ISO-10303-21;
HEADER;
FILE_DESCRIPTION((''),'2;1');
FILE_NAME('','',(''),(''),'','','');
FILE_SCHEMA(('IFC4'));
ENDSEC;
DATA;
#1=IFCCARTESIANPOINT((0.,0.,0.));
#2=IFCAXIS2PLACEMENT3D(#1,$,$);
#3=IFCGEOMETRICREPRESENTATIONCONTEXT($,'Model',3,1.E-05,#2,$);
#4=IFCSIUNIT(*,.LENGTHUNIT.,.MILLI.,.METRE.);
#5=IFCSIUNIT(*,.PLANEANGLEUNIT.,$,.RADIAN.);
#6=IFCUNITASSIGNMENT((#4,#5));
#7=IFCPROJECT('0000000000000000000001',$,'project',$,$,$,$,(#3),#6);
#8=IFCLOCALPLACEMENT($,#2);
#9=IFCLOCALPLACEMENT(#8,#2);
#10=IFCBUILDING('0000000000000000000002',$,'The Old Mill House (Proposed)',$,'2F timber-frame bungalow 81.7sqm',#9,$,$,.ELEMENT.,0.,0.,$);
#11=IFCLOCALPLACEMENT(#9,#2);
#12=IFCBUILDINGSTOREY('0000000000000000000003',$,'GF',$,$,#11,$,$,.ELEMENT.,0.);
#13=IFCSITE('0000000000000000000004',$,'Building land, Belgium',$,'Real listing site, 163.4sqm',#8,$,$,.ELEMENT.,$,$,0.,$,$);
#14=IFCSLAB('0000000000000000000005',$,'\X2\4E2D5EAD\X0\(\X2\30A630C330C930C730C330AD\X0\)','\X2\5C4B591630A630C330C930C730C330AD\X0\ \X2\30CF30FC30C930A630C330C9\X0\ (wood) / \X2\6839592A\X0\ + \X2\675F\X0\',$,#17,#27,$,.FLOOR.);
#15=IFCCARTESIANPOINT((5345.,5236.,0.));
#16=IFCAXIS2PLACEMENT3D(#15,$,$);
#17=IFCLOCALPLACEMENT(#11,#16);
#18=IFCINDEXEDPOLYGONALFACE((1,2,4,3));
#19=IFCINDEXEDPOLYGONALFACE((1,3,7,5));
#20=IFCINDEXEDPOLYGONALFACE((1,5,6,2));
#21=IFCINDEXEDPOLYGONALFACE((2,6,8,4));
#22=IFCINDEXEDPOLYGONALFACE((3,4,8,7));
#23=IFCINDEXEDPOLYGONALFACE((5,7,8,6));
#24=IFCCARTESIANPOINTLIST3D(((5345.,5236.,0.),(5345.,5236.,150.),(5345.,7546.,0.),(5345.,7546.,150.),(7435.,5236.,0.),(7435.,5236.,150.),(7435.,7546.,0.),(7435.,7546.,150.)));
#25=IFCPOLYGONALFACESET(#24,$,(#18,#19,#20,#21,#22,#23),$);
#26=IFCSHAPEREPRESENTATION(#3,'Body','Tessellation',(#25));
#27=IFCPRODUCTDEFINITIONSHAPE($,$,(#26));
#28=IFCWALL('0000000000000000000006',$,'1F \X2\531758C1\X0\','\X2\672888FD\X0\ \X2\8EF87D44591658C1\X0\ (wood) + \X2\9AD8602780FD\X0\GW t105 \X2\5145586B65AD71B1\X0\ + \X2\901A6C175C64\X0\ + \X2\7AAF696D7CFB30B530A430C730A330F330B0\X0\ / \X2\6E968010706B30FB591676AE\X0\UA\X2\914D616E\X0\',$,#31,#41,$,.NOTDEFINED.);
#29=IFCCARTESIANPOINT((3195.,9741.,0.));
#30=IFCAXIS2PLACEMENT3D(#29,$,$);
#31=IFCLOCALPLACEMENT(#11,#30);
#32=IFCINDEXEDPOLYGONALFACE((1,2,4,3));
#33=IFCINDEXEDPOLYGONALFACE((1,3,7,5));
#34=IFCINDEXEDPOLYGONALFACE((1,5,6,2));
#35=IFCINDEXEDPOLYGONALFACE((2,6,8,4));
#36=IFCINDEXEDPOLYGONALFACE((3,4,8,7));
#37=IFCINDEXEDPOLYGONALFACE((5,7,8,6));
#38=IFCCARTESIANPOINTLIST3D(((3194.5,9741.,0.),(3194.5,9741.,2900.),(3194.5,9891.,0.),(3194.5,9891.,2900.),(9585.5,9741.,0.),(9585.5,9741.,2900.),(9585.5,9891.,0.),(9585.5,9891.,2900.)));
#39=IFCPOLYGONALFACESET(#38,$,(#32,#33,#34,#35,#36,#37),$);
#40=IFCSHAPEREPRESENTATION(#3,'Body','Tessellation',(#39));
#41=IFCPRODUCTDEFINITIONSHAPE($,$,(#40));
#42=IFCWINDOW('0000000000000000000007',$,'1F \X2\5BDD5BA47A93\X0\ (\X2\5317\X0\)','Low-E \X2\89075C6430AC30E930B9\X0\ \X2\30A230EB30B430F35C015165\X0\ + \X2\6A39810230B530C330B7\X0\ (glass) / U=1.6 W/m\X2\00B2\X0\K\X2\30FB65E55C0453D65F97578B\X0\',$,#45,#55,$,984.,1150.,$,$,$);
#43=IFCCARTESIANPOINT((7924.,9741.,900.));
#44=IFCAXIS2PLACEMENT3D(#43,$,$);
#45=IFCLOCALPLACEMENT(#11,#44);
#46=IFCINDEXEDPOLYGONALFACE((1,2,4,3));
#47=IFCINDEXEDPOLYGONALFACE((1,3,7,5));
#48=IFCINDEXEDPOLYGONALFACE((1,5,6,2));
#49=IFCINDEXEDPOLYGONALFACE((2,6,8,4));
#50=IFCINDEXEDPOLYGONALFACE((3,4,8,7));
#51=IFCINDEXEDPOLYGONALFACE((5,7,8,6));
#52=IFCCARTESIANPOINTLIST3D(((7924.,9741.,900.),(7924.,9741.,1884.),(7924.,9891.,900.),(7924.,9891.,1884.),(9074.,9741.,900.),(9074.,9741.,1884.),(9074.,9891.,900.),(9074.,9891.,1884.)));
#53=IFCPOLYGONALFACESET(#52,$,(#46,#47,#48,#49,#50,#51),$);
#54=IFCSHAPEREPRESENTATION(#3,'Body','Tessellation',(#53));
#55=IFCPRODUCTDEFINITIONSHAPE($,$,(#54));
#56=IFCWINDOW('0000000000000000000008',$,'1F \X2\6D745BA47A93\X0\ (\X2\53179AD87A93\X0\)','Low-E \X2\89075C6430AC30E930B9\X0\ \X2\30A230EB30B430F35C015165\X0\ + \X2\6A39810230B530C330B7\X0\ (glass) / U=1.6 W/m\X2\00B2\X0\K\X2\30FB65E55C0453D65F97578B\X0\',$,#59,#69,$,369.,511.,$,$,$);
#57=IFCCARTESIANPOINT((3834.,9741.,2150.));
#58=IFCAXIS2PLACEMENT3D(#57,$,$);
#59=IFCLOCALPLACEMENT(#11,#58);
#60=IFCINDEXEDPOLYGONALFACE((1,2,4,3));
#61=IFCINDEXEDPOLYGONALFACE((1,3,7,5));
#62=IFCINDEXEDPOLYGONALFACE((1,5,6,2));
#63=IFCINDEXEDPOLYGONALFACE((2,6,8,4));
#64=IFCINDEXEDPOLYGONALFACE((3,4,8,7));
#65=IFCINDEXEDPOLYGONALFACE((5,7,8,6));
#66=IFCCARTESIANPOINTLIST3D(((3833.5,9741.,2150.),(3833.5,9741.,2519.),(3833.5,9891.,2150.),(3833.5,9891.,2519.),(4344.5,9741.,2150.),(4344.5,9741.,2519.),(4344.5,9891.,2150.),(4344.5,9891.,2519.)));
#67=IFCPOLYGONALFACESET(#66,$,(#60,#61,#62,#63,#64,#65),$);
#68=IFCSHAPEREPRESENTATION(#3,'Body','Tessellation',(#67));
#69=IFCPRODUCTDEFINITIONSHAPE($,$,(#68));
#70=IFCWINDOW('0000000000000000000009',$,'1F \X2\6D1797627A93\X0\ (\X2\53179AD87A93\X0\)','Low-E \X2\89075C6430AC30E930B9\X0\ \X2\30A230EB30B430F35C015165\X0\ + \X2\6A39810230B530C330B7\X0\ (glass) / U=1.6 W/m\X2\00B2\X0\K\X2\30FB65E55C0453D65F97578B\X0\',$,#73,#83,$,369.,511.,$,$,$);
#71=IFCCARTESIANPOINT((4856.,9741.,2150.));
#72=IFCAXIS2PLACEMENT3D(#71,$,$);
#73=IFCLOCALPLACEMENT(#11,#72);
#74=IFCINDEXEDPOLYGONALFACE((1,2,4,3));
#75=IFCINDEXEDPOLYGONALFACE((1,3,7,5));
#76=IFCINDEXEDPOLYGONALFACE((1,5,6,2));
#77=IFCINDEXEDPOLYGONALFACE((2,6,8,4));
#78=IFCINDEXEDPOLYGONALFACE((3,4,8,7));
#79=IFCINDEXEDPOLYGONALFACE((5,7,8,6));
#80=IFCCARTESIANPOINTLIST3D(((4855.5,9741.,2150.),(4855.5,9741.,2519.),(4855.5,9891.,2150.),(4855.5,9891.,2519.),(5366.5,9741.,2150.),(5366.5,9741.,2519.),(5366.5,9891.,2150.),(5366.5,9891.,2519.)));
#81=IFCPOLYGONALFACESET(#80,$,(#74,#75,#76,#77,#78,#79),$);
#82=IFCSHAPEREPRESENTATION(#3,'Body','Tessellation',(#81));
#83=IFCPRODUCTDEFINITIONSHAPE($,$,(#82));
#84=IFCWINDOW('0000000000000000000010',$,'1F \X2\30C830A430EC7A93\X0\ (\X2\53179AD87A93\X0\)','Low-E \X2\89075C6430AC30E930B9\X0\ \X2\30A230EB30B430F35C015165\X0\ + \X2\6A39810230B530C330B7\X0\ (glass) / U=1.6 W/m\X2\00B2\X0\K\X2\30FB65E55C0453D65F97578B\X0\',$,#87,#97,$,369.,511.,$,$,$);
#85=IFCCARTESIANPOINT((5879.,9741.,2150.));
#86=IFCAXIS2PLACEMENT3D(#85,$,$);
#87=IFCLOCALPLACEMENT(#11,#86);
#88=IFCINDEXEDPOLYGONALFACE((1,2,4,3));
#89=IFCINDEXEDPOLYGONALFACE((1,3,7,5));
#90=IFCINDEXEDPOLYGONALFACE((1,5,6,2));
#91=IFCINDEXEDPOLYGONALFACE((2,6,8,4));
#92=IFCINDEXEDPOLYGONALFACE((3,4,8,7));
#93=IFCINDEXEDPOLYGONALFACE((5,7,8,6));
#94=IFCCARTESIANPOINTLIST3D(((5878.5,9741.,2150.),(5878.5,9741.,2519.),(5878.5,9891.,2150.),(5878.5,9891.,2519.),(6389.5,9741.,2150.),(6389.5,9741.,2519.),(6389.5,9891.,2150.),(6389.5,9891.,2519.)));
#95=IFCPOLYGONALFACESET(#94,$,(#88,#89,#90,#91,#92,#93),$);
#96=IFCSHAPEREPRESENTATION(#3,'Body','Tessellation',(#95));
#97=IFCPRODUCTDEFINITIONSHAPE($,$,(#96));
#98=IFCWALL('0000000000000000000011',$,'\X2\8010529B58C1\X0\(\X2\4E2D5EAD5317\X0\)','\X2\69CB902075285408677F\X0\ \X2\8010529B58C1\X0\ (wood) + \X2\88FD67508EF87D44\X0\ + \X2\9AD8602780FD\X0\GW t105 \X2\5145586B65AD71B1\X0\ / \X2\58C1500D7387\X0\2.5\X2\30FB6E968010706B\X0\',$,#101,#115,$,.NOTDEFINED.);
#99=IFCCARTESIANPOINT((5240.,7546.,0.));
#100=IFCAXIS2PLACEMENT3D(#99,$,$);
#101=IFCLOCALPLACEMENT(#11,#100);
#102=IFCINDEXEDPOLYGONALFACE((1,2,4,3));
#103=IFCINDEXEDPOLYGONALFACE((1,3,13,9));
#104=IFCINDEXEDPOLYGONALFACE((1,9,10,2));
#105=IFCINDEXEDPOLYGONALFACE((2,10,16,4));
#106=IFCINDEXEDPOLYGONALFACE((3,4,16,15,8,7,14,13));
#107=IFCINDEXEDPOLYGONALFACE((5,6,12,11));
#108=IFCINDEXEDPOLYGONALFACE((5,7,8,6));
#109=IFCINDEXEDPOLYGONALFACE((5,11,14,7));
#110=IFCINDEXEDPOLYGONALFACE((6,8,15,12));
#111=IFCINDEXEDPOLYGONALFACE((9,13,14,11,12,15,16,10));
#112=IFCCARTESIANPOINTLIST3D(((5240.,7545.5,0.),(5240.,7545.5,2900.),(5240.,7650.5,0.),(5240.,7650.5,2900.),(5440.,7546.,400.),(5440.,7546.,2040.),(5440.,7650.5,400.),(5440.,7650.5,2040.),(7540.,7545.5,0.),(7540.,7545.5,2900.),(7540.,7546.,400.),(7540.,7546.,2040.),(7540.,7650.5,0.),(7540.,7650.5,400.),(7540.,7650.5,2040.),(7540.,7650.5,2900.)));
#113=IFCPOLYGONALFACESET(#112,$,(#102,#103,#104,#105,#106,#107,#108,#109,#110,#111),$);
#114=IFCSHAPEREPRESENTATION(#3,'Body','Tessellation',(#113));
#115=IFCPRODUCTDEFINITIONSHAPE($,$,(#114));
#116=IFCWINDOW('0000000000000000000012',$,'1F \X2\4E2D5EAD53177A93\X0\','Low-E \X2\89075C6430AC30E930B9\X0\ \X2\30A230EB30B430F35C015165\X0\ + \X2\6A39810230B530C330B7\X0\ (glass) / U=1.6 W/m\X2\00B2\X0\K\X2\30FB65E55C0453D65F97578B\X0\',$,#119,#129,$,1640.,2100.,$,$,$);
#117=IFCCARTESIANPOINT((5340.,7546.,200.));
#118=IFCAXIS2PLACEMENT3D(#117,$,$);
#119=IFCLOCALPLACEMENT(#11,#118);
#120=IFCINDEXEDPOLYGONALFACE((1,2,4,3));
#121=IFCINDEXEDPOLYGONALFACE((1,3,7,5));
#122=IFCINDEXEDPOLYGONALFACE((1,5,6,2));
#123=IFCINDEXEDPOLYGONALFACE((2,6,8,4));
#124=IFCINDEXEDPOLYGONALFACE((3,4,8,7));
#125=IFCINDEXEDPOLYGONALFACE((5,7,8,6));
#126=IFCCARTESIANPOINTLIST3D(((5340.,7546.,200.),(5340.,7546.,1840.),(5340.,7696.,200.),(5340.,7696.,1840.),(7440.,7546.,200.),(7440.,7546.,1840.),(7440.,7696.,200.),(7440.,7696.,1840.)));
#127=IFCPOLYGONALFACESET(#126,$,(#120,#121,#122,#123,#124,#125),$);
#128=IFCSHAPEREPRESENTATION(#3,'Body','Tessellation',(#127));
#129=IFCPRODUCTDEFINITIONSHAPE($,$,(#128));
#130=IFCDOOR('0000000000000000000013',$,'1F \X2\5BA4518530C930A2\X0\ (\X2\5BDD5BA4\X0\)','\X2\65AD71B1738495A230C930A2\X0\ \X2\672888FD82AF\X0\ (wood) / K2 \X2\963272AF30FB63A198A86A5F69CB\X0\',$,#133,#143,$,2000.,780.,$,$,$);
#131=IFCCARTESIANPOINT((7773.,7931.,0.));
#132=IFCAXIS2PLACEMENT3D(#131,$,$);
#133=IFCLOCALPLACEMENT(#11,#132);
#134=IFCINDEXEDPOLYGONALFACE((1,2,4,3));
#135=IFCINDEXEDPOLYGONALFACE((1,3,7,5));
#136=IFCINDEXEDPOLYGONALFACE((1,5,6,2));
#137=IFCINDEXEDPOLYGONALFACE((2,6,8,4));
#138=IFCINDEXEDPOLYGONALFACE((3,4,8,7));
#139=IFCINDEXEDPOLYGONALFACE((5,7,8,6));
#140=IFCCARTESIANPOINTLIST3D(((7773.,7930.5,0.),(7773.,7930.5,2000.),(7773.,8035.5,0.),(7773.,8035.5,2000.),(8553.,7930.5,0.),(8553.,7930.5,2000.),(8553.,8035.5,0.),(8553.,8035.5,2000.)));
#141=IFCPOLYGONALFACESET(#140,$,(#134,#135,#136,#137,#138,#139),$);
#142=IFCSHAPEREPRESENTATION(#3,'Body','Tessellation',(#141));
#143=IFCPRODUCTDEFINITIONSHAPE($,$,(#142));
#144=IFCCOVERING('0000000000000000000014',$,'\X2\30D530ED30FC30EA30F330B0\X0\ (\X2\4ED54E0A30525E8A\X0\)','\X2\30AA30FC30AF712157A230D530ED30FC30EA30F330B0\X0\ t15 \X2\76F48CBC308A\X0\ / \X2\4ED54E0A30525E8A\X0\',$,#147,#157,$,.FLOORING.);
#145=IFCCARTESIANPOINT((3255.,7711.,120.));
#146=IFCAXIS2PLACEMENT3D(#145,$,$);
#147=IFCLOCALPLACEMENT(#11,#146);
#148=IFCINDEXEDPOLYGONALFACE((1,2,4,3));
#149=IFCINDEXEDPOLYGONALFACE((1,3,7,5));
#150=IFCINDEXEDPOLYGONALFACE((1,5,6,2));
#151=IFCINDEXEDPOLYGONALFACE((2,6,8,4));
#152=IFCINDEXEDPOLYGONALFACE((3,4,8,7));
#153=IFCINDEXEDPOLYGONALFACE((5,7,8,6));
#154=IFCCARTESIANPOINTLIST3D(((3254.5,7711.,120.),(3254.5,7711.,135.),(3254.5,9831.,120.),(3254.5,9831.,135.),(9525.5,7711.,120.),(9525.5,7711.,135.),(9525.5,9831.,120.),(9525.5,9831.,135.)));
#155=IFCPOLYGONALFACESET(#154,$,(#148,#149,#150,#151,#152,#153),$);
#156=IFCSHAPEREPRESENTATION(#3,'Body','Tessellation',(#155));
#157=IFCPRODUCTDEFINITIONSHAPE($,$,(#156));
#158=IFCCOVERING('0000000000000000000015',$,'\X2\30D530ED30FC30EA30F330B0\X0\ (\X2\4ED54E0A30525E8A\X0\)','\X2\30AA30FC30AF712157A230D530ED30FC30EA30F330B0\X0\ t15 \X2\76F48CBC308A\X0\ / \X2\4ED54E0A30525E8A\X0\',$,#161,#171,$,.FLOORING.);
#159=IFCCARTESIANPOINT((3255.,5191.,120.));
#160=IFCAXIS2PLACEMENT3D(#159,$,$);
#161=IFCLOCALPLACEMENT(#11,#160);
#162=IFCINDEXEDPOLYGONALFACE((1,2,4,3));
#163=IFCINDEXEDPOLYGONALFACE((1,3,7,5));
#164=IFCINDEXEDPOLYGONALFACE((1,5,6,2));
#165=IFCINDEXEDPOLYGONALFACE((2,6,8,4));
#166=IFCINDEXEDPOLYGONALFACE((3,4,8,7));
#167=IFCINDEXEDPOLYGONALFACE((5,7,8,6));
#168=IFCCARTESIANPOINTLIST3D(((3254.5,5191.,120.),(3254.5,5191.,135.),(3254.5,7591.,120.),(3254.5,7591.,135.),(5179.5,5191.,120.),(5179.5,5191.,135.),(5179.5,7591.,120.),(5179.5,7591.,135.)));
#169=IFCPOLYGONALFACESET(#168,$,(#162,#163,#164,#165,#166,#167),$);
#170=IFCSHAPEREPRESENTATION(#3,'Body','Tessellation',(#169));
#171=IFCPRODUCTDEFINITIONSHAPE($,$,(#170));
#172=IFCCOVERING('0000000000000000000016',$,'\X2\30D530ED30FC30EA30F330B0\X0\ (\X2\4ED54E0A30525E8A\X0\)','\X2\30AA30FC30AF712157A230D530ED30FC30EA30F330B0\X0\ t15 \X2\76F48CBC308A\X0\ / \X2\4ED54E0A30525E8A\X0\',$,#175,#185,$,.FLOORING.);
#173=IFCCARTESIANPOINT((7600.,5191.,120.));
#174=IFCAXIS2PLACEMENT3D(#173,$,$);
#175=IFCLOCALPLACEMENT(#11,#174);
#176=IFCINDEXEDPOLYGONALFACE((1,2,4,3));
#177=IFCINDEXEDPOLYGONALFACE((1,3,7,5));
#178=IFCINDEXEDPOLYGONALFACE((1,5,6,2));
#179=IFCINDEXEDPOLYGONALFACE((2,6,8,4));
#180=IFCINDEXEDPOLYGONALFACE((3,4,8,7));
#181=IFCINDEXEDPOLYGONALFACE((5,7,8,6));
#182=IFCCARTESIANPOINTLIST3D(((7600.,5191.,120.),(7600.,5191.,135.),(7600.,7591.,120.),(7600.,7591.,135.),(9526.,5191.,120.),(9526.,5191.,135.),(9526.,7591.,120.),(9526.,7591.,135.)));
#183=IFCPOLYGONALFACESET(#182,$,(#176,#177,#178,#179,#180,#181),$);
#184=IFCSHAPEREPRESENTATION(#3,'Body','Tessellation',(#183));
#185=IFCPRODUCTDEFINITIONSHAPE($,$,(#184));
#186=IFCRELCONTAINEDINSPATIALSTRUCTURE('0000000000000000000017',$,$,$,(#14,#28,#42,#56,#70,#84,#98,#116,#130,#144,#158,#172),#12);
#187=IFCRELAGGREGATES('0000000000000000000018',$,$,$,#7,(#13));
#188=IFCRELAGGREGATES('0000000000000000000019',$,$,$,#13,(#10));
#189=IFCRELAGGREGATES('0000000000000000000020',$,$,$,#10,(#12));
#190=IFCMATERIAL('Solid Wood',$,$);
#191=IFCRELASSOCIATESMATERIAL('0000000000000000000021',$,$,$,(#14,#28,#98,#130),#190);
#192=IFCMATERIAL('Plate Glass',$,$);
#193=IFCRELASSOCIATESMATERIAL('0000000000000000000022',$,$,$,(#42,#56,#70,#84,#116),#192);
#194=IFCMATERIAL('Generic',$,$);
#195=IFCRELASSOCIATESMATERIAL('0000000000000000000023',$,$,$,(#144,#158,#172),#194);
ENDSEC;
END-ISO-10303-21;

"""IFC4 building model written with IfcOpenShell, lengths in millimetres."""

from ifc_helpers import new_model, si_unit, frame, frame_2d, origin, place, context, project, spatial, rectangle, extrude, material, element, fill, save


model = new_model("IFC4")

# Units and contexts
model_context = context("Model", 3, precision=1e-05, world=origin())
ifc_project = project(units=[si_unit("LENGTHUNIT", "METRE", prefix="MILLI"), si_unit("PLANEANGLEUNIT", "RADIAN")], contexts=[model_context])

# Site, building, storey
site_placement = place(None, origin())
site = spatial("IfcSite", under=ifc_project, at=site_placement, Name="Building land, Belgium", ObjectType="Real listing site, 163.4sqm", CompositionType="ELEMENT", RefElevation=0.0)
building_placement = place(site_placement, origin())
building = spatial("IfcBuilding", under=site, at=building_placement, Name="The Old Mill House (Proposed)", ObjectType="2F timber-frame bungalow 81.7sqm", CompositionType="ELEMENT", ElevationOfRefHeight=0.0, ElevationOfTerrain=0.0)
storey_placement = place(building_placement, origin())
storey = spatial("IfcBuildingStorey", under=building, at=storey_placement, Name="GF", CompositionType="ELEMENT", Elevation=0.0)

# Slab
ifc_material_1 = material(Name="Solid Wood")
slab_1_placement = place(storey_placement, frame((5345.0, 5236.0, 0.0)))
element("IfcSlab", 1, at=slab_1_placement, inside=storey, material=ifc_material_1, Name="中庭(ウッドデッキ)", Description="屋外ウッドデッキ ハードウッド (wood) / 根太 + 束", PredefinedType="FLOOR", context=model_context, shape_type="SweptSolid", body=[
    extrude(rectangle(XDim=2090.0, YDim=2310.0, at=frame_2d((1045.0, 1155.0))), frame((5345.0, 5236.0, 0.0)), (0.0, 0.0, 1.0), 150.0),
])

# Wall, openings, windows
wall_1_placement = place(storey_placement, frame((3195.0, 9741.0, 0.0)))
wall_1 = element("IfcWall", 2, at=wall_1_placement, inside=storey, material=ifc_material_1, Name="1F 北壁", Description="木製 軸組外壁 (wood) + 高性能GW t105 充填断熱 + 通気層 + 窯業系サイディング / 準耐火・外皮UA配慮", PredefinedType="NOTDEFINED", context=model_context, shape_type="SweptSolid", body=[
    extrude(rectangle(XDim=6391.0, YDim=150.0, at=frame_2d((3195.0, 75.0))), frame((3195.0, 9741.0, 0.0)), (0.0, 0.0, 1.0), 2900.0),
])
opening_1_placement = place(storey_placement, frame((7924.0, 9741.0, 900.0)))
opening_1 = element("IfcOpeningElement", 3, at=opening_1_placement, cuts=wall_1, PredefinedType="NOTDEFINED", context=model_context, shape_type="SweptSolid", body=[
    extrude(rectangle(XDim=1150.0, YDim=150.0, at=frame_2d((575.0, 75.0))), frame((7924.0, 9741.0, 900.0)), (0.0, 0.0, 1.0), 984.0),
])
opening_2_placement = place(storey_placement, frame((3834.0, 9741.0, 2150.0)))
opening_2 = element("IfcOpeningElement", 4, at=opening_2_placement, cuts=wall_1, PredefinedType="NOTDEFINED", context=model_context, shape_type="SweptSolid", body=[
    extrude(rectangle(XDim=511.0, YDim=150.0, at=frame_2d((255.0, 75.0))), frame((3834.0, 9741.0, 2150.0)), (0.0, 0.0, 1.0), 369.0),
])
opening_3_placement = place(storey_placement, frame((4856.0, 9741.0, 2150.0)))
opening_3 = element("IfcOpeningElement", 5, at=opening_3_placement, cuts=wall_1, PredefinedType="NOTDEFINED", context=model_context, shape_type="SweptSolid", body=[
    extrude(rectangle(XDim=511.0, YDim=150.0, at=frame_2d((255.0, 75.0))), frame((4856.0, 9741.0, 2150.0)), (0.0, 0.0, 1.0), 369.0),
])
opening_4_placement = place(storey_placement, frame((5879.0, 9741.0, 2150.0)))
opening_4 = element("IfcOpeningElement", 6, at=opening_4_placement, cuts=wall_1, PredefinedType="NOTDEFINED", context=model_context, shape_type="SweptSolid", body=[
    extrude(rectangle(XDim=511.0, YDim=150.0, at=frame_2d((255.0, 75.0))), frame((5879.0, 9741.0, 2150.0)), (0.0, 0.0, 1.0), 369.0),
])
ifc_material_2 = material(Name="Plate Glass")
window_1_placement = place(storey_placement, frame((7924.0, 9741.0, 900.0)))
window_1 = element("IfcWindow", 7, at=window_1_placement, inside=storey, material=ifc_material_2, Name="1F 寝室窓 (北)", Description="Low-E 複層ガラス アルゴン封入 + 樹脂サッシ (glass) / U=1.6 W/m²K・日射取得型", OverallHeight=984.0, OverallWidth=1150.0, context=model_context, shape_type="SweptSolid", body=[
    extrude(rectangle(XDim=1150.0, YDim=150.0, at=frame_2d((575.0, 75.0))), frame((7924.0, 9741.0, 900.0)), (0.0, 0.0, 1.0), 984.0),
])
fill(opening_1, window_1)
window_2_placement = place(storey_placement, frame((3834.0, 9741.0, 2150.0)))
window_2 = element("IfcWindow", 8, at=window_2_placement, inside=storey, material=ifc_material_2, Name="1F 浴室窓 (北高窓)", Description="Low-E 複層ガラス アルゴン封入 + 樹脂サッシ (glass) / U=1.6 W/m²K・日射取得型", OverallHeight=369.0, OverallWidth=511.0, context=model_context, shape_type="SweptSolid", body=[
    extrude(rectangle(XDim=511.0, YDim=150.0, at=frame_2d((255.0, 75.0))), frame((3834.0, 9741.0, 2150.0)), (0.0, 0.0, 1.0), 369.0),
])
fill(opening_2, window_2)
window_3_placement = place(storey_placement, frame((4856.0, 9741.0, 2150.0)))
window_3 = element("IfcWindow", 9, at=window_3_placement, inside=storey, material=ifc_material_2, Name="1F 洗面窓 (北高窓)", Description="Low-E 複層ガラス アルゴン封入 + 樹脂サッシ (glass) / U=1.6 W/m²K・日射取得型", OverallHeight=369.0, OverallWidth=511.0, context=model_context, shape_type="SweptSolid", body=[
    extrude(rectangle(XDim=511.0, YDim=150.0, at=frame_2d((255.0, 75.0))), frame((4856.0, 9741.0, 2150.0)), (0.0, 0.0, 1.0), 369.0),
])
fill(opening_3, window_3)
window_4_placement = place(storey_placement, frame((5879.0, 9741.0, 2150.0)))
window_4 = element("IfcWindow", 10, at=window_4_placement, inside=storey, material=ifc_material_2, Name="1F トイレ窓 (北高窓)", Description="Low-E 複層ガラス アルゴン封入 + 樹脂サッシ (glass) / U=1.6 W/m²K・日射取得型", OverallHeight=369.0, OverallWidth=511.0, context=model_context, shape_type="SweptSolid", body=[
    extrude(rectangle(XDim=511.0, YDim=150.0, at=frame_2d((255.0, 75.0))), frame((5879.0, 9741.0, 2150.0)), (0.0, 0.0, 1.0), 369.0),
])
fill(opening_4, window_4)

# Wall, opening, window
wall_2_placement = place(storey_placement, frame((5240.0, 7546.0, 0.0)))
wall_2 = element("IfcWall", 11, at=wall_2_placement, inside=storey, material=ifc_material_1, Name="耐力壁(中庭北)", Description="構造用合板 耐力壁 (wood) + 製材軸組 + 高性能GW t105 充填断熱 / 壁倍率2.5・準耐火", PredefinedType="NOTDEFINED", context=model_context, shape_type="SweptSolid", body=[
    extrude(rectangle(XDim=2300.0, YDim=105.0, at=frame_2d((1150.0, 52.0))), frame((5240.0, 7546.0, 0.0)), (0.0, 0.0, 1.0), 2900.0),
])
opening_5_placement = place(storey_placement, frame((5340.0, 7546.0, 200.0)))
opening_5 = element("IfcOpeningElement", 12, at=opening_5_placement, cuts=wall_2, PredefinedType="NOTDEFINED", context=model_context, shape_type="SweptSolid", body=[
    extrude(rectangle(XDim=2100.0, YDim=150.0, at=frame_2d((1050.0, 75.0))), frame((5340.0, 7546.0, 200.0)), (0.0, 0.0, 1.0), 1640.0),
])
window_5_placement = place(storey_placement, frame((5340.0, 7546.0, 200.0)))
window_5 = element("IfcWindow", 13, at=window_5_placement, inside=storey, material=ifc_material_2, Name="1F 中庭北窓", Description="Low-E 複層ガラス アルゴン封入 + 樹脂サッシ (glass) / U=1.6 W/m²K・日射取得型", OverallHeight=1640.0, OverallWidth=2100.0, context=model_context, shape_type="SweptSolid", body=[
    extrude(rectangle(XDim=2100.0, YDim=150.0, at=frame_2d((1050.0, 75.0))), frame((5340.0, 7546.0, 200.0)), (0.0, 0.0, 1.0), 1640.0),
])
fill(opening_5, window_5)

# Door
door_1_placement = place(storey_placement, frame((7773.0, 7931.0, 0.0)))
element("IfcDoor", 14, at=door_1_placement, inside=storey, material=ifc_material_1, Name="1F 室内ドア (寝室)", Description="断熱玄関ドア 木製芯 (wood) / K2 防犯・採風機構", OverallHeight=2000.0, OverallWidth=780.0, context=model_context, shape_type="SweptSolid", body=[
    extrude(rectangle(XDim=780.0, YDim=105.0, at=frame_2d((390.0, 52.0))), frame((7773.0, 7931.0, 0.0)), (0.0, 0.0, 1.0), 2000.0),
])

# Coverings
ifc_material_3 = material(Name="Generic")
covering_1_placement = place(storey_placement, frame((3255.0, 7711.0, 120.0)))
element("IfcCovering", 15, at=covering_1_placement, inside=storey, material=ifc_material_3, Name="フローリング (仕上げ床)", Description="オーク無垢フローリング t15 直貼り / 仕上げ床", PredefinedType="FLOORING", context=model_context, shape_type="SweptSolid", body=[
    extrude(rectangle(XDim=6271.0, YDim=2120.0, at=frame_2d((3135.0, 1060.0))), frame((3255.0, 7711.0, 120.0)), (0.0, 0.0, 1.0), 15.0),
])
covering_2_placement = place(storey_placement, frame((3255.0, 5191.0, 120.0)))
element("IfcCovering", 16, at=covering_2_placement, inside=storey, material=ifc_material_3, Name="フローリング (仕上げ床)", Description="オーク無垢フローリング t15 直貼り / 仕上げ床", PredefinedType="FLOORING", context=model_context, shape_type="SweptSolid", body=[
    extrude(rectangle(XDim=1925.0, YDim=2400.0, at=frame_2d((962.0, 1200.0))), frame((3255.0, 5191.0, 120.0)), (0.0, 0.0, 1.0), 15.0),
])
covering_3_placement = place(storey_placement, frame((7600.0, 5191.0, 120.0)))
element("IfcCovering", 17, at=covering_3_placement, inside=storey, material=ifc_material_3, Name="フローリング (仕上げ床)", Description="オーク無垢フローリング t15 直貼り / 仕上げ床", PredefinedType="FLOORING", context=model_context, shape_type="SweptSolid", body=[
    extrude(rectangle(XDim=1926.0, YDim=2400.0, at=frame_2d((963.0, 1200.0))), frame((7600.0, 5191.0, 120.0)), (0.0, 0.0, 1.0), 15.0),
])

save(model, "model.ifc")
